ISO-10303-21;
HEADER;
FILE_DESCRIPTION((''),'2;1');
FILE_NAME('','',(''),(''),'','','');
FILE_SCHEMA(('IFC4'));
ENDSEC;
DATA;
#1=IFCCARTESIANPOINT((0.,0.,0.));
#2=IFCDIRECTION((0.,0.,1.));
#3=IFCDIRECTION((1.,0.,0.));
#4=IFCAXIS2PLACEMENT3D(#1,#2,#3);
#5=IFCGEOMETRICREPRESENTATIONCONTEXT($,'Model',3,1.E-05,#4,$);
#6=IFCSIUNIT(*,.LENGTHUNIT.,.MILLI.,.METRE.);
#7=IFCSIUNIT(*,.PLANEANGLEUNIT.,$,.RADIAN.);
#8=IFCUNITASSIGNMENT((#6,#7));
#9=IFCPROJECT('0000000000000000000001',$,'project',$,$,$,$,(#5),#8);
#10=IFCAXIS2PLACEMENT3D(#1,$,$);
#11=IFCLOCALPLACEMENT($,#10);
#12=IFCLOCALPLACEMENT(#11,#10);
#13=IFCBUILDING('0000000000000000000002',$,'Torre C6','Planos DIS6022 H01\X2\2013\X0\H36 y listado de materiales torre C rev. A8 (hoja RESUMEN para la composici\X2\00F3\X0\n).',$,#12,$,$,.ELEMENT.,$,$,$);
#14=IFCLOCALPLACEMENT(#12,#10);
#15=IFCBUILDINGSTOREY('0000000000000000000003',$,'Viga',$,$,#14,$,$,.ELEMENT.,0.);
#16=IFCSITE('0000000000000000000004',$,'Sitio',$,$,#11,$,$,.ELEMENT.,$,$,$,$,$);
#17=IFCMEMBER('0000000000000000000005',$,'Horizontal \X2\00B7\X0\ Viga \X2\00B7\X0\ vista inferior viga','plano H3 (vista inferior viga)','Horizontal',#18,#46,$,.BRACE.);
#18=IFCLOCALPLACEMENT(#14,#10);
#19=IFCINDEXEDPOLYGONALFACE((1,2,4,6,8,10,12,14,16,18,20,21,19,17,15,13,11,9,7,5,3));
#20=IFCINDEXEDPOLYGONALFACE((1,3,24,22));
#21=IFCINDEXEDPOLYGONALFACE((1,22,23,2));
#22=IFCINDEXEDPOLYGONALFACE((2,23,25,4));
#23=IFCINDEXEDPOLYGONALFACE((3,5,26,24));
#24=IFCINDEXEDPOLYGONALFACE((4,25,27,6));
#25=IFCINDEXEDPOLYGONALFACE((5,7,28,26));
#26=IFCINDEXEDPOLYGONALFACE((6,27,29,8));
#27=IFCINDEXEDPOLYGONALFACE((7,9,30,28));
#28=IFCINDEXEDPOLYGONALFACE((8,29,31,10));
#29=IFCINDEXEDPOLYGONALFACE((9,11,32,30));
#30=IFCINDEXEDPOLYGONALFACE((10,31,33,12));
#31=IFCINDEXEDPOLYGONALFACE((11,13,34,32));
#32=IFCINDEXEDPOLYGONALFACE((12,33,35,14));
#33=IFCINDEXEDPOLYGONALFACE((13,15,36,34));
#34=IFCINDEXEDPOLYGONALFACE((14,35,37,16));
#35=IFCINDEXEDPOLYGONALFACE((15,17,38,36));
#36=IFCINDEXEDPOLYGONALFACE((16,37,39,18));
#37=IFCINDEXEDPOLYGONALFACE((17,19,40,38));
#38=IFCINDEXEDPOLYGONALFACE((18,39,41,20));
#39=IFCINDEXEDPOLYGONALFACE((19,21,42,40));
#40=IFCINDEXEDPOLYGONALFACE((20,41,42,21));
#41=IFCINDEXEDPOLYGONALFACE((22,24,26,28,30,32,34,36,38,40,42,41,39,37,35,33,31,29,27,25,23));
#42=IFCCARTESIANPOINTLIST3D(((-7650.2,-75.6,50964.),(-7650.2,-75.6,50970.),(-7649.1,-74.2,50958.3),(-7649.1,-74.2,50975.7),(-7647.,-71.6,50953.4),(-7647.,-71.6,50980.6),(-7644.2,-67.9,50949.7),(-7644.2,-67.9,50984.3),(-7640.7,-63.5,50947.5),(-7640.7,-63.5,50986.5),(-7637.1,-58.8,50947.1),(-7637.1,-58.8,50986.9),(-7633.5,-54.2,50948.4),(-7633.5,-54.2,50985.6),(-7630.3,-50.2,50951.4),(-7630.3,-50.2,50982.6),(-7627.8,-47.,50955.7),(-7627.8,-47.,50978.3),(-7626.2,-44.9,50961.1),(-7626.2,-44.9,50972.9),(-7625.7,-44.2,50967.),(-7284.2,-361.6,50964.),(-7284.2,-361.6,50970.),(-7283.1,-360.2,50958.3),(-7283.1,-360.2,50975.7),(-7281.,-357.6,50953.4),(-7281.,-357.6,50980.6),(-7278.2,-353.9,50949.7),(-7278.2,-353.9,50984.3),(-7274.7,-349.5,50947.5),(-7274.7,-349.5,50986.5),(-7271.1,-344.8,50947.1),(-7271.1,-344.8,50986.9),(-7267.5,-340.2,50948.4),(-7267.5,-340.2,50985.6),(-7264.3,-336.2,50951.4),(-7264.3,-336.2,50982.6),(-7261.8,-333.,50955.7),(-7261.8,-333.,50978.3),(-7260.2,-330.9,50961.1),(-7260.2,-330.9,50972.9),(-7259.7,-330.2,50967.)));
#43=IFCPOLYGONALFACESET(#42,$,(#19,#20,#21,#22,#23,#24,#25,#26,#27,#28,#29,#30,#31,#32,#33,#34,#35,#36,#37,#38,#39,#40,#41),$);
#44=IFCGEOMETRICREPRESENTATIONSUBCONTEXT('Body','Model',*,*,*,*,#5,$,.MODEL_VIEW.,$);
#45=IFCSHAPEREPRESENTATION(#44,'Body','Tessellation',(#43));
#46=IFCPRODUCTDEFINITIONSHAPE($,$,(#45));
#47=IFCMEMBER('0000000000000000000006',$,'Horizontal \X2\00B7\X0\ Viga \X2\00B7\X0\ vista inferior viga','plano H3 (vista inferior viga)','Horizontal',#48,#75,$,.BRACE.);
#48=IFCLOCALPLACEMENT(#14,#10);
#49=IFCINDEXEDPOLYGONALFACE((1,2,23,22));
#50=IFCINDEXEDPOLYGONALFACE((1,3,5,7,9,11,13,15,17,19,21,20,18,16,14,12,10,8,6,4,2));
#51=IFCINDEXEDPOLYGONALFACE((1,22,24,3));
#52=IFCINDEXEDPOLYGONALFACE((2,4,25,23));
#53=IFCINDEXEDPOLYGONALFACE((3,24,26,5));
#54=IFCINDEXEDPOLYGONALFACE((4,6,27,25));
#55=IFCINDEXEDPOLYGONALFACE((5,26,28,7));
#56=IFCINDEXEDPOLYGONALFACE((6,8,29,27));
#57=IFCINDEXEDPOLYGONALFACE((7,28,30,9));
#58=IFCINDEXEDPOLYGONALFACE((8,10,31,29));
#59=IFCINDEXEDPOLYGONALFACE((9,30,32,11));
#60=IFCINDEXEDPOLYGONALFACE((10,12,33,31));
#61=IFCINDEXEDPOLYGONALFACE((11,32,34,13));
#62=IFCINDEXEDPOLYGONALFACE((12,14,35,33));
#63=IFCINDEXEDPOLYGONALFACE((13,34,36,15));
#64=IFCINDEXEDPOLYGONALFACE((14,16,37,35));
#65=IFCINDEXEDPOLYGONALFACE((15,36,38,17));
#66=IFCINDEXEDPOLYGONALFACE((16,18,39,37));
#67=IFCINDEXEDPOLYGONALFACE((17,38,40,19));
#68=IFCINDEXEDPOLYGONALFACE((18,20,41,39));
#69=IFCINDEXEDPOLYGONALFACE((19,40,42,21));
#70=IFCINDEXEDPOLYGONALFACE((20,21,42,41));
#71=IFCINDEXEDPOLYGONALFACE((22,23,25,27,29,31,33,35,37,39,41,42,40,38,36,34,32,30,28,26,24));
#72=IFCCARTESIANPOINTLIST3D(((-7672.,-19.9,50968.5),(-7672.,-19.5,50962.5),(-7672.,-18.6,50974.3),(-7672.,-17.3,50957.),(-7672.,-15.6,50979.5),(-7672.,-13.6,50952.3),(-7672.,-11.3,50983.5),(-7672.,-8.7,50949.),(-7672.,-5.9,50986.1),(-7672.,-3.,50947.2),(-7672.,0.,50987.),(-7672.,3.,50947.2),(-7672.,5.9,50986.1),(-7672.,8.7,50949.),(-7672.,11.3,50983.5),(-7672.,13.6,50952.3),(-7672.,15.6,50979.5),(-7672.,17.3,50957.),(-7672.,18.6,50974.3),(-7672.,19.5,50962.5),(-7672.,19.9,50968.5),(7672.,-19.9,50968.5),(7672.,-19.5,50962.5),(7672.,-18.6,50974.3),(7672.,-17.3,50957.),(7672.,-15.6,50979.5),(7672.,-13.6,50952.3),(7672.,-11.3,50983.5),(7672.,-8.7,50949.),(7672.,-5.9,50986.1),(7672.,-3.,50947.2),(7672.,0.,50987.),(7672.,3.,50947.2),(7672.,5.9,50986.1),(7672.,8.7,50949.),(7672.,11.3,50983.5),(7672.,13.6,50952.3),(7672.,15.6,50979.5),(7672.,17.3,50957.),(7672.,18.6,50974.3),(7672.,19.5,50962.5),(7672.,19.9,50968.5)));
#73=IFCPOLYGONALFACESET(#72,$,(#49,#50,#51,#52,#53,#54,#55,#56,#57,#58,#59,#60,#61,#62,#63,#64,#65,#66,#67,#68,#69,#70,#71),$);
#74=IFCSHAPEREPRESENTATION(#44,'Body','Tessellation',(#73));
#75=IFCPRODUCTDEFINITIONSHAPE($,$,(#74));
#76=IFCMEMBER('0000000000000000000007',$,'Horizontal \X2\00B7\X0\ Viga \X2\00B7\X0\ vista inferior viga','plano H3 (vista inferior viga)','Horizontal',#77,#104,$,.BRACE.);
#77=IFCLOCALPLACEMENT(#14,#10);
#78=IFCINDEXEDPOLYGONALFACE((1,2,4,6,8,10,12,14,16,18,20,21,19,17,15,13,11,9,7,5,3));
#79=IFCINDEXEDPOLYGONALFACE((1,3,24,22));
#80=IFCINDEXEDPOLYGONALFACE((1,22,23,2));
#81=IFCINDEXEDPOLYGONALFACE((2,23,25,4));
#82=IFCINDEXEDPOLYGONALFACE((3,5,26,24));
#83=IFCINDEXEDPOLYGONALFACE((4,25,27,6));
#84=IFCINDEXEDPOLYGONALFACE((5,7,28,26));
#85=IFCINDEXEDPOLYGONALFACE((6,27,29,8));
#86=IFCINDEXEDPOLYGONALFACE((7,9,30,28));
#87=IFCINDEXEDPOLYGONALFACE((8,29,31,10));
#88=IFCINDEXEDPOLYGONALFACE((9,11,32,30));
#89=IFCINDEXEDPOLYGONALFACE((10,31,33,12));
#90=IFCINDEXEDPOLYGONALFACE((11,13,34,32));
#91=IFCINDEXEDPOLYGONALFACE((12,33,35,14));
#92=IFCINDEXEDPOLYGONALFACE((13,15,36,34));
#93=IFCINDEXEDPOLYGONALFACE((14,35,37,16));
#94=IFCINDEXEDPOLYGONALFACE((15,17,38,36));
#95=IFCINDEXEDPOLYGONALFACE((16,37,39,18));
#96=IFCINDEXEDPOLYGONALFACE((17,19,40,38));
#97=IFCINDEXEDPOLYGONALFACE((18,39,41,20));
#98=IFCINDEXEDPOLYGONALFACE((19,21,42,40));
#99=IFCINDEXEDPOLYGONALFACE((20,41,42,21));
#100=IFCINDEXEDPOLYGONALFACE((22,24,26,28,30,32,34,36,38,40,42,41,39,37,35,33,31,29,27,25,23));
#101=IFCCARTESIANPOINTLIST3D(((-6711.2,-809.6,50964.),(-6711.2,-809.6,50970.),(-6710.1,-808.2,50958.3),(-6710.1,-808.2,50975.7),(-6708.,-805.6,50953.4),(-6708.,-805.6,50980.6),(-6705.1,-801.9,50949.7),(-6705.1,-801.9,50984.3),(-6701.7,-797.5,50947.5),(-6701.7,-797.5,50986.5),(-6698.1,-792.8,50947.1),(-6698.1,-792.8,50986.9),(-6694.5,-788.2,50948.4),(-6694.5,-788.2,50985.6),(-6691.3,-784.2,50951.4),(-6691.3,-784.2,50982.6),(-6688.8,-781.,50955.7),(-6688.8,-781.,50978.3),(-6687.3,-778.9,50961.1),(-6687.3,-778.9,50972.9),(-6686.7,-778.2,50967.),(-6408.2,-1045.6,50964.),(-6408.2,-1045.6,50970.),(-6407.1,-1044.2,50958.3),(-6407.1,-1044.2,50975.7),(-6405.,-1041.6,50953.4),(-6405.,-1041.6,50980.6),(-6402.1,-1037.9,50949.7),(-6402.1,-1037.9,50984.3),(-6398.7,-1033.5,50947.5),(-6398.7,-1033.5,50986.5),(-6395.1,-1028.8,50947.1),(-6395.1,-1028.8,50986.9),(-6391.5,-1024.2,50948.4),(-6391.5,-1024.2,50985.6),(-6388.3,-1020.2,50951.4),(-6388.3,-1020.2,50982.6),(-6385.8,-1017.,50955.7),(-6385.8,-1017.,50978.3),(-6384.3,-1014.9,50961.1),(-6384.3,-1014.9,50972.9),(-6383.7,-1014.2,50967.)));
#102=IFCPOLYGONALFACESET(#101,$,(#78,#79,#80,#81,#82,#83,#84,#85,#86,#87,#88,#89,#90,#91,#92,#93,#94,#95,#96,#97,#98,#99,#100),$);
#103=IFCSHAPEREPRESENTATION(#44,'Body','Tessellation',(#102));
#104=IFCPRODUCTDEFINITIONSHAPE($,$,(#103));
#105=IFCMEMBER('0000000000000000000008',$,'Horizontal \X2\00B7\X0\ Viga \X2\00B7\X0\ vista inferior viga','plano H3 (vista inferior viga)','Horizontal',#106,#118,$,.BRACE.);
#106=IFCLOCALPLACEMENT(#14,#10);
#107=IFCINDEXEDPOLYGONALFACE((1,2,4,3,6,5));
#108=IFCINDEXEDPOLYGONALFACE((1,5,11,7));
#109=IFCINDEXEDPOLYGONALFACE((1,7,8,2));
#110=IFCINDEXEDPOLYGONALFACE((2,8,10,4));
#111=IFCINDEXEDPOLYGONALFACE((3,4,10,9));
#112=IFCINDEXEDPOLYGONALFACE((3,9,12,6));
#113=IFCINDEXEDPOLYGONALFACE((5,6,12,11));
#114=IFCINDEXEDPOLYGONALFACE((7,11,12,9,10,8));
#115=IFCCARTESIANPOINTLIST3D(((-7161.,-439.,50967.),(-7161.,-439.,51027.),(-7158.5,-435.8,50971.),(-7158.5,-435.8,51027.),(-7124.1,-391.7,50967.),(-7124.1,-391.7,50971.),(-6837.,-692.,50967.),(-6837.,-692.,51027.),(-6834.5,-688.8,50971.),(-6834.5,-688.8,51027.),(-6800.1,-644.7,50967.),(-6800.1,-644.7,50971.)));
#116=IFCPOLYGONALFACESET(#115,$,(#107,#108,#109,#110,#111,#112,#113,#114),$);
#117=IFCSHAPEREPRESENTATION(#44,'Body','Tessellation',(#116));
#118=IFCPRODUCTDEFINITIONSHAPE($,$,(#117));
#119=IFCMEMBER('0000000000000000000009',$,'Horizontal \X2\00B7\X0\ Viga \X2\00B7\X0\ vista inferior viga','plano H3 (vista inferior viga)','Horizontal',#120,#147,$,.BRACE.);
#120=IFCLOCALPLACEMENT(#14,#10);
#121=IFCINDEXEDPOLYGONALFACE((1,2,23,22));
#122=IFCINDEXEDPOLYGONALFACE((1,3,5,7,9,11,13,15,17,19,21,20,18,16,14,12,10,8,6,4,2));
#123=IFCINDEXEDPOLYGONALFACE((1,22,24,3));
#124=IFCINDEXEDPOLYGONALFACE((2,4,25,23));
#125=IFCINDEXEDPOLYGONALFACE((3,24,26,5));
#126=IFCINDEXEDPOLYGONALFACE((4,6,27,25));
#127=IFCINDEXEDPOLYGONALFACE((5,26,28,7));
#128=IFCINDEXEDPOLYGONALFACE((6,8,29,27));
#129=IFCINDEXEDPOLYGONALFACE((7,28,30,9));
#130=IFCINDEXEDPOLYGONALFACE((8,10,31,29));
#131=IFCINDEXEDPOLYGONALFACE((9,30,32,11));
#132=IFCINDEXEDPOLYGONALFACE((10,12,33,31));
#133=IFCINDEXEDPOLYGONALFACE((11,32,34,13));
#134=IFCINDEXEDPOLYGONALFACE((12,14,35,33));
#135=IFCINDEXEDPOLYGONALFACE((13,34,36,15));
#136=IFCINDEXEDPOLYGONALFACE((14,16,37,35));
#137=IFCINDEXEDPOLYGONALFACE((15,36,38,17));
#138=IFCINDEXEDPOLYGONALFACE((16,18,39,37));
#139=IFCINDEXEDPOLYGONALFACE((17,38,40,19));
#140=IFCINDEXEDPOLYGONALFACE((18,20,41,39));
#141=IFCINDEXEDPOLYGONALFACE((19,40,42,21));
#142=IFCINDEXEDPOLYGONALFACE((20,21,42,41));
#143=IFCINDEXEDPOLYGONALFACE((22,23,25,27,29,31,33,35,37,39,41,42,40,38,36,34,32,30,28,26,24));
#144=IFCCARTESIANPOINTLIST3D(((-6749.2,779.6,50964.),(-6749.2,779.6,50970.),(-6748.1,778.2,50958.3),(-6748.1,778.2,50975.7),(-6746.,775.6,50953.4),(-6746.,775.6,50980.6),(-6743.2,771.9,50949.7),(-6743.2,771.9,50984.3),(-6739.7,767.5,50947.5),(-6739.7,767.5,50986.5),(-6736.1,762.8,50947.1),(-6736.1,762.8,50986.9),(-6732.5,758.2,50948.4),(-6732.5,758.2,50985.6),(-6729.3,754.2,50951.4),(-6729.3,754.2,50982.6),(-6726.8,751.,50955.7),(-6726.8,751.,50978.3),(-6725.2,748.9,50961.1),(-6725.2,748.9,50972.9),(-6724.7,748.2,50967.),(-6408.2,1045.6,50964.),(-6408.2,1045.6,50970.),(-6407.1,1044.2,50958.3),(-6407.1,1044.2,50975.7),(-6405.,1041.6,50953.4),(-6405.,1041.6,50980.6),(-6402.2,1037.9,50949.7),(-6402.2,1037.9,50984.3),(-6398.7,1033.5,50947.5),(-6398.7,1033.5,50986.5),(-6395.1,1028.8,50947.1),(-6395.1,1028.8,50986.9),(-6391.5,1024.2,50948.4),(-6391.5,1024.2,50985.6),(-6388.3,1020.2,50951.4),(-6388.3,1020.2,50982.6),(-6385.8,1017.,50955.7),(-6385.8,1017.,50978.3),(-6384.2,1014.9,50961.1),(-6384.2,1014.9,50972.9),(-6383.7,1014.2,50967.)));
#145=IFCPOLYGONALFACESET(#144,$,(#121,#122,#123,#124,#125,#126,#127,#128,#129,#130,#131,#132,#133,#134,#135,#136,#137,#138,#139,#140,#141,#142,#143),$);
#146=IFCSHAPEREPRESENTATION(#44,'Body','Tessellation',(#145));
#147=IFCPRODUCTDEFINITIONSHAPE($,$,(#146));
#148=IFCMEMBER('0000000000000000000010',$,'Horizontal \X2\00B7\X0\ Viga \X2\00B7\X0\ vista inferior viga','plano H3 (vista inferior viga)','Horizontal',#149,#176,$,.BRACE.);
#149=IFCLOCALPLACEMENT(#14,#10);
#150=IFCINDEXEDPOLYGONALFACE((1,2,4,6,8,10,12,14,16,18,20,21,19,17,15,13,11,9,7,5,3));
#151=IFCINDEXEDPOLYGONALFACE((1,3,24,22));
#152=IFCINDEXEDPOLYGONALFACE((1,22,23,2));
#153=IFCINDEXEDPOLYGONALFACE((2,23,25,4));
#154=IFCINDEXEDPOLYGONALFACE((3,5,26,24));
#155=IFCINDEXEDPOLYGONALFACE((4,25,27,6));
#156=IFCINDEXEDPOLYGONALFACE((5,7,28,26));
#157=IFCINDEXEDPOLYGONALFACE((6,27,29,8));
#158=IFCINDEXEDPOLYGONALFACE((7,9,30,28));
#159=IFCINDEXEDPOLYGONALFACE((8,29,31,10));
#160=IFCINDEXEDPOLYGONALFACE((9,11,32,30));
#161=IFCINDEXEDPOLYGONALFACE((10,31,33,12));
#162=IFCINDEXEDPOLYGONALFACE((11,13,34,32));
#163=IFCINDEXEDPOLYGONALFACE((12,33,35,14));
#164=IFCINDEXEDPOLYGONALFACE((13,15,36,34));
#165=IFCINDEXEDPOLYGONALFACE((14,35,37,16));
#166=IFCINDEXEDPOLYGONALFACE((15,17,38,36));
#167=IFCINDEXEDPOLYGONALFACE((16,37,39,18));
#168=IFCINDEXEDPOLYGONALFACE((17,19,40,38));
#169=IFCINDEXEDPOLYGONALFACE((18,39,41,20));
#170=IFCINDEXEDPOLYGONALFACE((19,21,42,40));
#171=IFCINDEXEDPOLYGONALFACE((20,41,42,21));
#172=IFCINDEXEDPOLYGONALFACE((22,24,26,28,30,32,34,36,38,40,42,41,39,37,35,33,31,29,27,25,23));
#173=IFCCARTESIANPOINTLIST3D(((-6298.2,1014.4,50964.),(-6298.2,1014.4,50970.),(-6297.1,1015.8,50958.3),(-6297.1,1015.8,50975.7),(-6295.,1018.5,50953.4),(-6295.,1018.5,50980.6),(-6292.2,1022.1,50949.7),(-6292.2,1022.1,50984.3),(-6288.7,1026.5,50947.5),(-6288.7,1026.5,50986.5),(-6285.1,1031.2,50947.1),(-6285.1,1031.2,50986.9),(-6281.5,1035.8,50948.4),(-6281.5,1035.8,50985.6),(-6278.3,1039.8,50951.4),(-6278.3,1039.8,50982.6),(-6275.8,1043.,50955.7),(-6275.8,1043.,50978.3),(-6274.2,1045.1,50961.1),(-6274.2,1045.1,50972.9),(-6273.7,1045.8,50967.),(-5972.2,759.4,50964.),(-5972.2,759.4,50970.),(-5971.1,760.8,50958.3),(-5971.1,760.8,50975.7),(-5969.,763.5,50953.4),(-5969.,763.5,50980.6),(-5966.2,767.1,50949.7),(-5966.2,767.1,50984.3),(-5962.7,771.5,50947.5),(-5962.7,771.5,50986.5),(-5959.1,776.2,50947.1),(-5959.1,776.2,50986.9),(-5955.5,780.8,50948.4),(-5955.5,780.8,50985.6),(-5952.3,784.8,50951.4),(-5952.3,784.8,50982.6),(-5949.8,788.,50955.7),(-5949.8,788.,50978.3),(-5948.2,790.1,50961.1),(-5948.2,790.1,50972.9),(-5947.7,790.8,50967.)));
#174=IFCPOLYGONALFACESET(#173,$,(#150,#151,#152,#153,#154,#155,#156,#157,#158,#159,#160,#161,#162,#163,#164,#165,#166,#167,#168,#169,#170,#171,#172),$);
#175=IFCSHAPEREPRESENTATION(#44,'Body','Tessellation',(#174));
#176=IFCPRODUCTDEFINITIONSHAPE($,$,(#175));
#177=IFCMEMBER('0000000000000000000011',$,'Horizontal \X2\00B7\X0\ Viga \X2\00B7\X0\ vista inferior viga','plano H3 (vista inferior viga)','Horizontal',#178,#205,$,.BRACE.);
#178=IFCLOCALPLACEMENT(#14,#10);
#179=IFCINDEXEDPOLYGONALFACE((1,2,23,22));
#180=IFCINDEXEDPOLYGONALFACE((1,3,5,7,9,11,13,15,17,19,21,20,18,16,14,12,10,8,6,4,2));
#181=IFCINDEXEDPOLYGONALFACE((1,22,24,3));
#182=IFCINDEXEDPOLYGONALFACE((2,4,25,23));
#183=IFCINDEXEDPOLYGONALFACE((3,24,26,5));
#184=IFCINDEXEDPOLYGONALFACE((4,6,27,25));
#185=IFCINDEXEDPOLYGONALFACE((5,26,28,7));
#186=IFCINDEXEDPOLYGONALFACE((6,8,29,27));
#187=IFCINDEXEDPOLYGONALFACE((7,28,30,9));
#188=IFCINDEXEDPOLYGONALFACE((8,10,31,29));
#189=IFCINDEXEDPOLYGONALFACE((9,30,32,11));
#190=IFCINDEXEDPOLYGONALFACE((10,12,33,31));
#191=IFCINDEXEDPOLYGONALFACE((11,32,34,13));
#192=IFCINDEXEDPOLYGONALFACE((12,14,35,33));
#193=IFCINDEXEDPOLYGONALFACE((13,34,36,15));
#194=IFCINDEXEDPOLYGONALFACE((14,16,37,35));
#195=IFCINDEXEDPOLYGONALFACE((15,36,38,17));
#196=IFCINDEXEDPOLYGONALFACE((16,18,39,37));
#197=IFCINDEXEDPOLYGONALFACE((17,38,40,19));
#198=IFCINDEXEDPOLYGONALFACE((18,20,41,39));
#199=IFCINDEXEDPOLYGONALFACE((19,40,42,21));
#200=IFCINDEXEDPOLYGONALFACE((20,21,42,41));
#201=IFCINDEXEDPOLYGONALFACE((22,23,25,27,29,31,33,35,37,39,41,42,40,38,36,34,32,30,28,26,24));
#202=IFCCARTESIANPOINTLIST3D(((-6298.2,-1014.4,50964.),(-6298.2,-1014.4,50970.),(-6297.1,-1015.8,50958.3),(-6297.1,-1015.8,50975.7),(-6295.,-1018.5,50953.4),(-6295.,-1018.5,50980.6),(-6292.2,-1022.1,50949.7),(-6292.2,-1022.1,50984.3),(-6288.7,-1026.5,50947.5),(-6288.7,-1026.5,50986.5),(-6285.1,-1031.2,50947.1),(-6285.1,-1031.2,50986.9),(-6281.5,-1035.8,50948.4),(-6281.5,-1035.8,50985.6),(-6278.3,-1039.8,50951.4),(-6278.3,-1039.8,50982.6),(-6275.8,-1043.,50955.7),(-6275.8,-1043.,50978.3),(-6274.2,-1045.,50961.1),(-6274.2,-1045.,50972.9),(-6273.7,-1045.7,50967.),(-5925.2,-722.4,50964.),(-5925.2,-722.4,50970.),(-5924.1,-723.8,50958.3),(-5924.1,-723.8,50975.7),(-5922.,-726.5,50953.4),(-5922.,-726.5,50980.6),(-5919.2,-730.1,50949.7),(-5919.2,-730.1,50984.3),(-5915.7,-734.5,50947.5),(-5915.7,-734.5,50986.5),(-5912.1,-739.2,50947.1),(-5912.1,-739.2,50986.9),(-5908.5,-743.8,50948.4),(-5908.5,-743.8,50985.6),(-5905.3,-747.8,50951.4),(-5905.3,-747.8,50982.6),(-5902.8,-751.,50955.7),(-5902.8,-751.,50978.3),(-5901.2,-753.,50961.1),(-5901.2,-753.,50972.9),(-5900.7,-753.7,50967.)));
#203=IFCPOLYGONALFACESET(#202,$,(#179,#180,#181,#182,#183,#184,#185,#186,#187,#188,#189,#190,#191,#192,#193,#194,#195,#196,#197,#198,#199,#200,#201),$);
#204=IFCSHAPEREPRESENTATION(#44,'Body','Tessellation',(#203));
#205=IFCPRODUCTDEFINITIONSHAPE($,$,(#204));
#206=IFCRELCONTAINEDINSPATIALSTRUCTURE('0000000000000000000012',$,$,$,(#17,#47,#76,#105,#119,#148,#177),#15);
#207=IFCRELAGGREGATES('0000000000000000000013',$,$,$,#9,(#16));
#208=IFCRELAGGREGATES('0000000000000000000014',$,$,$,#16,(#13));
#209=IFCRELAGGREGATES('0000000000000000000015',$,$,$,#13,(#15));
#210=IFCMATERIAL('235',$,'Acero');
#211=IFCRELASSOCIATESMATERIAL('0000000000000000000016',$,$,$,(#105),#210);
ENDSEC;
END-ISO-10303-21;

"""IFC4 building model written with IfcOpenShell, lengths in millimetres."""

from ifc_helpers import new_model, si_unit, frame, frame_2d, origin, origin_with_axes, place, context, subcontext, project, spatial, circle, l_section, extrude, material, element, save


model = new_model("IFC4")

# Units and contexts
model_context = context("Model", 3, precision=1e-05, world=origin_with_axes())
body_context = subcontext(model_context, "Body", "Model", "MODEL_VIEW")
ifc_project = project(units=[si_unit("LENGTHUNIT", "METRE", prefix="MILLI"), si_unit("PLANEANGLEUNIT", "RADIAN")], contexts=[model_context])

# Site, building, storey
site_placement = place(None, origin())
site = spatial("IfcSite", under=ifc_project, at=site_placement, Name="Sitio", CompositionType="ELEMENT")
building_placement = place(site_placement, origin())
building = spatial("IfcBuilding", under=site, at=building_placement, Name="Torre C6", Description="Planos DIS6022 H01–H36 y listado de materiales torre C rev. A8 (hoja RESUMEN para la composición).", CompositionType="ELEMENT")
storey_placement = place(building_placement, origin())
storey = spatial("IfcBuildingStorey", under=building, at=storey_placement, Name="Viga", CompositionType="ELEMENT", Elevation=0.0)

# Members
ifc_material_1 = material(Name="235", Category="Acero")
member_1_placement = place(storey_placement, frame((-7638.0, -60.0, 50967.0), z_axis=(0.787959, -0.615728, 0.0), x_axis=(0.615728, 0.787959, 0.0)))
element("IfcMember", 1, at=member_1_placement, inside=storey, Name="Horizontal · Viga · vista inferior viga", Description="plano H3 (vista inferior viga)", ObjectType="Horizontal", PredefinedType="BRACE", context=body_context, shape_type="SweptSolid", body=[
    extrude(circle(Radius=20.0), None, (0.0, 0.0, 1.0), 464.5),
])
member_2_placement = place(storey_placement, frame((-7672.0, 0.0, 50967.0), z_axis=(1.0, 0.0, 0.0), x_axis=(0.0, 0.0, 1.0)))
element("IfcMember", 2, at=member_2_placement, inside=storey, Name="Horizontal · Viga · vista inferior viga", Description="plano H3 (vista inferior viga)", ObjectType="Horizontal", PredefinedType="BRACE", context=body_context, shape_type="SweptSolid", body=[
    extrude(circle(Radius=20.0), None, (0.0, 0.0, 1.0), 15344.0),
])
member_3_placement = place(storey_placement, frame((-6699.0, -794.0, 50967.0), z_axis=(0.788931, -0.614481, 0.0), x_axis=(0.614481, 0.788931, 0.0)))
element("IfcMember", 3, at=member_3_placement, inside=storey, Name="Horizontal · Viga · vista inferior viga", Description="plano H3 (vista inferior viga)", ObjectType="Horizontal", PredefinedType="BRACE", context=body_context, shape_type="SweptSolid", body=[
    extrude(circle(Radius=20.0), None, (0.0, 0.0, 1.0), 384.1),
])
member_4_placement = place(storey_placement, frame((-7161.0, -439.0, 50967.0), z_axis=(0.788172, -0.615455, 0.0), x_axis=(0.615455, 0.788172, 0.0)))
element("IfcMember", 4, at=member_4_placement, inside=storey, material=ifc_material_1, Name="Horizontal · Viga · vista inferior viga", Description="plano H3 (vista inferior viga)", ObjectType="Horizontal", PredefinedType="BRACE", context=body_context, shape_type="SweptSolid", body=[
    extrude(l_section(Depth=60.0, Width=60.0, Thickness=4.0, at=frame_2d((30.0, 30.0))), None, (0.0, 0.0, 1.0), 411.1),
])
member_5_placement = place(storey_placement, frame((-6737.0, 764.0, 50967.0), z_axis=(0.78848, 0.615061, 0.0), x_axis=(0.615061, -0.78848, 0.0)))
element("IfcMember", 5, at=member_5_placement, inside=storey, Name="Horizontal · Viga · vista inferior viga", Description="plano H3 (vista inferior viga)", ObjectType="Horizontal", PredefinedType="BRACE", context=body_context, shape_type="SweptSolid", body=[
    extrude(circle(Radius=20.0), None, (0.0, 0.0, 1.0), 432.5),
])
member_6_placement = place(storey_placement, frame((-5960.0, 775.0, 50967.0), z_axis=(-0.787658, 0.616113, 0.0), x_axis=(0.616113, 0.787658, 0.0)))
element("IfcMember", 6, at=member_6_placement, inside=storey, Name="Horizontal · Viga · vista inferior viga", Description="plano H3 (vista inferior viga)", ObjectType="Horizontal", PredefinedType="BRACE", context=body_context, shape_type="SweptSolid", body=[
    extrude(circle(Radius=20.0), None, (0.0, 0.0, 1.0), 413.9),
])
member_7_placement = place(storey_placement, frame((-5913.0, -738.0, 50967.0), z_axis=(-0.787416, -0.616422, 0.0), x_axis=(0.616422, -0.787416, 0.0)))
element("IfcMember", 7, at=member_7_placement, inside=storey, Name="Horizontal · Viga · vista inferior viga", Description="plano H3 (vista inferior viga)", ObjectType="Horizontal", PredefinedType="BRACE", context=body_context, shape_type="SweptSolid", body=[
    extrude(circle(Radius=20.0), None, (0.0, 0.0, 1.0), 473.7),
])

save(model, "model.ifc")
